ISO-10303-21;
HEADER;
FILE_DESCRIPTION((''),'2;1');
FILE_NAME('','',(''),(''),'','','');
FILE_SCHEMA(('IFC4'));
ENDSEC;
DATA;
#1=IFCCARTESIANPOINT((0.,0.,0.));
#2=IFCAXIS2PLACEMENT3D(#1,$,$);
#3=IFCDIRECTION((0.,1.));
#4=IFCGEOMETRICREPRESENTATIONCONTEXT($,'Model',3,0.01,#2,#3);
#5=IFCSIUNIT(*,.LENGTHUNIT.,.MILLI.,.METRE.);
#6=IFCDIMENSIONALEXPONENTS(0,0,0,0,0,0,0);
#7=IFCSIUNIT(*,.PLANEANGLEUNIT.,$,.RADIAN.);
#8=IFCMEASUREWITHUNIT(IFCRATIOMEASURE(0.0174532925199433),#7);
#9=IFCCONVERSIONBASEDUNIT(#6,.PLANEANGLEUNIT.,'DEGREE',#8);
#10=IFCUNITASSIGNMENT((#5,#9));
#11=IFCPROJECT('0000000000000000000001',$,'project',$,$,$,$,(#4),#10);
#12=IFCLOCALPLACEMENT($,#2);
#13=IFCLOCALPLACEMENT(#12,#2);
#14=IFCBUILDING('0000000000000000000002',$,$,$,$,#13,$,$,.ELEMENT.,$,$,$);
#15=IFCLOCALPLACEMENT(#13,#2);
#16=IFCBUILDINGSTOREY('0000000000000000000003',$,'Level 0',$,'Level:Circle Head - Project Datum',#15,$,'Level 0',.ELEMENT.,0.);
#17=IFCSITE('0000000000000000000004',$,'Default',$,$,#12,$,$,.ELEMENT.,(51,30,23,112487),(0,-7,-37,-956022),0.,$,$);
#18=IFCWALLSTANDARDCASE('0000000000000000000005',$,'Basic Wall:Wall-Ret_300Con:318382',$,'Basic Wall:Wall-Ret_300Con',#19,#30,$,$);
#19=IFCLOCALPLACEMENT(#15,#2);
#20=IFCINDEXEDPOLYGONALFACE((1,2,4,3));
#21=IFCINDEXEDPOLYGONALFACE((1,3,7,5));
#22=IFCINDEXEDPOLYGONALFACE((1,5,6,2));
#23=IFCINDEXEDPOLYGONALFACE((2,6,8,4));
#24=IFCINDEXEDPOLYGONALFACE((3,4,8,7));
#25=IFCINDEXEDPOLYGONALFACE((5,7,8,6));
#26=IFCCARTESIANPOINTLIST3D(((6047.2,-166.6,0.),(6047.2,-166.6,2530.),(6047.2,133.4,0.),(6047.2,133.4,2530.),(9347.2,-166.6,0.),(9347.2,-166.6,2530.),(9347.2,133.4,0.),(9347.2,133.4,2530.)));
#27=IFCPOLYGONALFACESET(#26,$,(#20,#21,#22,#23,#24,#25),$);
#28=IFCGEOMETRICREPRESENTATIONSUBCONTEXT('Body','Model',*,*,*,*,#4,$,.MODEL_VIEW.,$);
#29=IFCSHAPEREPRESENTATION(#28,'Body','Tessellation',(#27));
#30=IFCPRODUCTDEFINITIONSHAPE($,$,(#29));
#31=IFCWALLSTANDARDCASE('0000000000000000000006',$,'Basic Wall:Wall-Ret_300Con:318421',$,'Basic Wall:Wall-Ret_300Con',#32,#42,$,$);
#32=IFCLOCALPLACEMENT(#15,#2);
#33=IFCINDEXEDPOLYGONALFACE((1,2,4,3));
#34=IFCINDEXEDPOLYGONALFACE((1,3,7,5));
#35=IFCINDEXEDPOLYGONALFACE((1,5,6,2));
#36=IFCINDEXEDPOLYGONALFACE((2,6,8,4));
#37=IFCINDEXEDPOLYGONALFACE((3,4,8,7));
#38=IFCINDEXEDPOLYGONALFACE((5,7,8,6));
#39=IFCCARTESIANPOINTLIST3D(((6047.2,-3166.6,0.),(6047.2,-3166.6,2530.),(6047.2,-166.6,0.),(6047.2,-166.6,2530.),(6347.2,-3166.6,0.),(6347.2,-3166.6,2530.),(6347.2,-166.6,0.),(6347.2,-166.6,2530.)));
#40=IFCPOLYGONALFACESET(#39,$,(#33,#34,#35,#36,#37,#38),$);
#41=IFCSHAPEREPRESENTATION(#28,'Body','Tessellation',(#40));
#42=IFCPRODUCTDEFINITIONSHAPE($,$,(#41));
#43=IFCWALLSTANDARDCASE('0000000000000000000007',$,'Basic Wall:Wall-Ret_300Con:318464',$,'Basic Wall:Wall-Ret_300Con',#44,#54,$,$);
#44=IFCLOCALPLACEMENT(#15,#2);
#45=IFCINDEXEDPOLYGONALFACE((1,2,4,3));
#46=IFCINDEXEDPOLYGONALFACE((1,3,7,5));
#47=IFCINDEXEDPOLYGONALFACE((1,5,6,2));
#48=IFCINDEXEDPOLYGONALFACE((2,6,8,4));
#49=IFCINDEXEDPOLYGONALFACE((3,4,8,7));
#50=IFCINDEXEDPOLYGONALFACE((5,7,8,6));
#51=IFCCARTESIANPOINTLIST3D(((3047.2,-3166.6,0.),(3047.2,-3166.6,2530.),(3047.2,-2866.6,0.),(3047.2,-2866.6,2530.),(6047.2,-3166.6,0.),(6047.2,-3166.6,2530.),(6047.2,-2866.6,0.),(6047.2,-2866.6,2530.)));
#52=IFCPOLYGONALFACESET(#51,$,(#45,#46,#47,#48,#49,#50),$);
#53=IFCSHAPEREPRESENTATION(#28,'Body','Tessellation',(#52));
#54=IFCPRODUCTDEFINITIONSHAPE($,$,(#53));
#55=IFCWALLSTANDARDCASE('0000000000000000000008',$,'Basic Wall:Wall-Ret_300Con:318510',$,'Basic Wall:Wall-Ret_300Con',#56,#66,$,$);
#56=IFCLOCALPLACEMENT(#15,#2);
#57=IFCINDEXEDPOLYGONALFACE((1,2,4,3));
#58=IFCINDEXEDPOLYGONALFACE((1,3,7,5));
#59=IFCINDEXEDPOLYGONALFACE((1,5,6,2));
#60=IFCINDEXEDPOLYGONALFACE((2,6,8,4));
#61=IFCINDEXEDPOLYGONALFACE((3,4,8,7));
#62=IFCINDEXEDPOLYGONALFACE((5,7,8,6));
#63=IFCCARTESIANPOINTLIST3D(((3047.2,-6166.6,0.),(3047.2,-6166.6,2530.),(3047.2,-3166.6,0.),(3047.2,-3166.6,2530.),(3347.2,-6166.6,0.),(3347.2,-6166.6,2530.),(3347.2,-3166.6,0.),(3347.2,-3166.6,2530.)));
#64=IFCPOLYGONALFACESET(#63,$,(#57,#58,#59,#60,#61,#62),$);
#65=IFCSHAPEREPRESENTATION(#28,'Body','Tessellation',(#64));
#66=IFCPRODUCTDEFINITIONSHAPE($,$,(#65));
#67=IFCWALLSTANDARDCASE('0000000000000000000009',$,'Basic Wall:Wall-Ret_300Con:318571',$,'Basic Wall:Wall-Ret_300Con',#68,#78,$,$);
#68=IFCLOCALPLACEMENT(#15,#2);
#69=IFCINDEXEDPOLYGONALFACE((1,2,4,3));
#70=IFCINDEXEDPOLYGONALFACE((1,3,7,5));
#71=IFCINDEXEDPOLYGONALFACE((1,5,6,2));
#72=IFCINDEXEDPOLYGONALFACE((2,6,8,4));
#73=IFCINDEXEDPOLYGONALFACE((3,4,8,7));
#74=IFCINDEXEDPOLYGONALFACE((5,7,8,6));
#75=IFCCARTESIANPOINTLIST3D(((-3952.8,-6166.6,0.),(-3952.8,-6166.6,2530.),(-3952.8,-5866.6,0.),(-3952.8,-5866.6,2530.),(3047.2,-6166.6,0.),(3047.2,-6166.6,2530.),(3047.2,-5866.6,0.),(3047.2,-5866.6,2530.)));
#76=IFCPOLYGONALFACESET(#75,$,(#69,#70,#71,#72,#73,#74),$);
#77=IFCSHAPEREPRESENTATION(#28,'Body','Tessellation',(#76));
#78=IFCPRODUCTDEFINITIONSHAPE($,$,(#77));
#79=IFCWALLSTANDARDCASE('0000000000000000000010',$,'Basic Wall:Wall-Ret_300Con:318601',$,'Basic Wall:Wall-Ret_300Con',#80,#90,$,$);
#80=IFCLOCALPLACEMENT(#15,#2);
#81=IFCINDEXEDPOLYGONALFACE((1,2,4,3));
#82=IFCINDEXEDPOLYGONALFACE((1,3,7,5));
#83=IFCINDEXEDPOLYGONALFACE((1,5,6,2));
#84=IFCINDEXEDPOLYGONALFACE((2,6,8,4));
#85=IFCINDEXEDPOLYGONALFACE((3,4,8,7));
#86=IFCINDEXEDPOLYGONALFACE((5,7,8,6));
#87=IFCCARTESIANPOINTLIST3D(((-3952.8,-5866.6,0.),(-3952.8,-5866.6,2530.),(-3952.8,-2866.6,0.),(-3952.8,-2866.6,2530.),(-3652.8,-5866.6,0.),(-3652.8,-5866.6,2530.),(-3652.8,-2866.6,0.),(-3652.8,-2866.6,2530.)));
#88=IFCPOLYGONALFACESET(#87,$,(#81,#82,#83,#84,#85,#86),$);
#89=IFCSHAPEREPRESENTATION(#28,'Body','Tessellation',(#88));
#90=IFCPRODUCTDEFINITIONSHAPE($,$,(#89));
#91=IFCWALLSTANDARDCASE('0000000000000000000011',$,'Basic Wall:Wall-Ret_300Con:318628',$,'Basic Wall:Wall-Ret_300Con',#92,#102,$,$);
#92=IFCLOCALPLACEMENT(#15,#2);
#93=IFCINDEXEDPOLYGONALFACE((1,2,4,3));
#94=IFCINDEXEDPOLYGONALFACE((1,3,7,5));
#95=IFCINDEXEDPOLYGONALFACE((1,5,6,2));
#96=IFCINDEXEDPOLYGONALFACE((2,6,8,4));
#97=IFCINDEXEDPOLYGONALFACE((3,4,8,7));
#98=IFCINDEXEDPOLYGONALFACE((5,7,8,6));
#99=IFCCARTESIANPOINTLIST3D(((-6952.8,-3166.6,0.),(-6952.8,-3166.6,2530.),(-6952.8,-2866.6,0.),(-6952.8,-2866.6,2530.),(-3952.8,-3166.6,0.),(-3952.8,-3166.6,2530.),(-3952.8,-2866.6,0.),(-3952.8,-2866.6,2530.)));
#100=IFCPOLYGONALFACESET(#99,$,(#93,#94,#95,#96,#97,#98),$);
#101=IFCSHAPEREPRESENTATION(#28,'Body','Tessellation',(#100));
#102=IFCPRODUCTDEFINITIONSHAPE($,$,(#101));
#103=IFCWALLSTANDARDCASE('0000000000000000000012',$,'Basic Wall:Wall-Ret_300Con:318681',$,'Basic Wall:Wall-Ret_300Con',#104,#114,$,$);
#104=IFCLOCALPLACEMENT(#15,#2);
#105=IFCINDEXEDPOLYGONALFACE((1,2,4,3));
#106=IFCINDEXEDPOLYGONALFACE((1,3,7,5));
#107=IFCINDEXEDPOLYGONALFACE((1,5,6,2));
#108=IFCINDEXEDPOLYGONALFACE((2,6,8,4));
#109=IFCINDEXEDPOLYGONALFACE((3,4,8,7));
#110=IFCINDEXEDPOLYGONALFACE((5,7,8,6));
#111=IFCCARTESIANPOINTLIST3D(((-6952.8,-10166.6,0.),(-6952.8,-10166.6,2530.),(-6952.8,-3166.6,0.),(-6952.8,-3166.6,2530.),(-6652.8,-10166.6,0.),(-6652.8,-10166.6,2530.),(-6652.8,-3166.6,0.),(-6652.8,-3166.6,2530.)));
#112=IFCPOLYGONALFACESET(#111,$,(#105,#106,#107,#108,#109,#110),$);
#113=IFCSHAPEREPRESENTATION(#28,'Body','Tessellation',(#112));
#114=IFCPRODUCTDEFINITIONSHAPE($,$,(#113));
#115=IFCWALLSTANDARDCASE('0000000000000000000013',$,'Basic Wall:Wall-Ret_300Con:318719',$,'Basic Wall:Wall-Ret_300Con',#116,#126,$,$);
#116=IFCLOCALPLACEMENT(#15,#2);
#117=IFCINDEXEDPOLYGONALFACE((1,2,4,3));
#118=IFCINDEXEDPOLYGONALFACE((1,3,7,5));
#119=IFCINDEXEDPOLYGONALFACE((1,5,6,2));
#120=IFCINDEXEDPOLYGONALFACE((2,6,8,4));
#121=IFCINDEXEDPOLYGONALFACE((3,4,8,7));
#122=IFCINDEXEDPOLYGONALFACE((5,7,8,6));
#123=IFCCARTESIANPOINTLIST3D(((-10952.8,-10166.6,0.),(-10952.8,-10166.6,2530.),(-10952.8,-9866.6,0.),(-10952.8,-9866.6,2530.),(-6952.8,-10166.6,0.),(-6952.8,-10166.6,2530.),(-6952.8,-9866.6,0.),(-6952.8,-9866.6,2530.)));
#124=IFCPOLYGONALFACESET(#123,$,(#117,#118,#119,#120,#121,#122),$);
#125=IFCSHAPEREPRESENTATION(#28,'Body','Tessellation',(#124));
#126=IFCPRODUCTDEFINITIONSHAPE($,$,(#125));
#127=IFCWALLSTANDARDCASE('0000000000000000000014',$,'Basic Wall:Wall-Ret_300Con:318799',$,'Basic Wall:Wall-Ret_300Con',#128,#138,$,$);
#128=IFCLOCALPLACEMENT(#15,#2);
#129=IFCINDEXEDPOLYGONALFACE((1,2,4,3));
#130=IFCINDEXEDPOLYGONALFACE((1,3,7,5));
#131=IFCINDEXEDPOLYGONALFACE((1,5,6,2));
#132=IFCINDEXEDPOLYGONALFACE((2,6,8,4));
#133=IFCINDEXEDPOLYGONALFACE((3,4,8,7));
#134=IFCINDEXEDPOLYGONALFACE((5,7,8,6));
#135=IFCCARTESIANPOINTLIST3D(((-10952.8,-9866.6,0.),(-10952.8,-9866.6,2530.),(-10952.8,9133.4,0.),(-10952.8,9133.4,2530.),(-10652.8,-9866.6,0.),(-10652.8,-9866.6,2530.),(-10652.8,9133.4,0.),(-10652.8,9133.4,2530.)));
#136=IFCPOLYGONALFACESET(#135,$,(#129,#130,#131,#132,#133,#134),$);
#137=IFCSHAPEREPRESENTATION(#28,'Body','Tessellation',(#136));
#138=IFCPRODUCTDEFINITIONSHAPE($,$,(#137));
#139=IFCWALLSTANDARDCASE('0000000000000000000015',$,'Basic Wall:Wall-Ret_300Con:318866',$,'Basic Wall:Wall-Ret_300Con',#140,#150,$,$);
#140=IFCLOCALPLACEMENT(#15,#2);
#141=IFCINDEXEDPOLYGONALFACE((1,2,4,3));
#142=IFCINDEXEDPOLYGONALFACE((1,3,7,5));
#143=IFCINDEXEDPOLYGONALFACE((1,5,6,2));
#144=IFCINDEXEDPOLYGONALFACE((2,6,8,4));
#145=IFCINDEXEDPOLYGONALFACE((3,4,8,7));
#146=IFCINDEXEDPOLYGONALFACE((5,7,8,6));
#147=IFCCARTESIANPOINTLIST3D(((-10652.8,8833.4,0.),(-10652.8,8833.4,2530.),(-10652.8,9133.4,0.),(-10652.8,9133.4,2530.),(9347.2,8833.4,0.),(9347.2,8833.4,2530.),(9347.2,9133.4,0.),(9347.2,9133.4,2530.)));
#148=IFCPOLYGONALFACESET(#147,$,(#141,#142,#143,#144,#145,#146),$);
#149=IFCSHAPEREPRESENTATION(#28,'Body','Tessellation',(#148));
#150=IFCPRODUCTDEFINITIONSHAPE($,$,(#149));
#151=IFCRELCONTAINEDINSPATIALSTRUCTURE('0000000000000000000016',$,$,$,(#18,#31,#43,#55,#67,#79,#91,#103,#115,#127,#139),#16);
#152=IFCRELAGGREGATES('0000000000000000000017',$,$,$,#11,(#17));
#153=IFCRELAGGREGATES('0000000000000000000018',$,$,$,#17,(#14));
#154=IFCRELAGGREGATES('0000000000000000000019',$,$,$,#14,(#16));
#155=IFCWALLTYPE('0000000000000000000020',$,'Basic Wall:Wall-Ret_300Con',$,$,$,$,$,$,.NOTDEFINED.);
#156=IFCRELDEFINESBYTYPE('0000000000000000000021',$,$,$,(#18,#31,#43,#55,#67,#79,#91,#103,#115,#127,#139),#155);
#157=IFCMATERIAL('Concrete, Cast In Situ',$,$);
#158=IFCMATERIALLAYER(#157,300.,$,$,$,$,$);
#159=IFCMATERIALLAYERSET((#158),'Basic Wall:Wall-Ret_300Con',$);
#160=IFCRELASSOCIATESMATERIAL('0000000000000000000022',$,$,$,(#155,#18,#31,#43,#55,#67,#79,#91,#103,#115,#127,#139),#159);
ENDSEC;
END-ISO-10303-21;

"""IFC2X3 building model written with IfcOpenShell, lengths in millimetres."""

from ifc_helpers import new_model, entity, si_unit, converted_unit, direction, frame, frame_2d, origin, place, context, subcontext, project, spatial, polyline, rectangle, extrude, clip, bounded_halfspace, material, layer, layer_set, layer_usage, type_object, element, save


model = new_model("IFC2X3")

# Units and contexts
model_context = context("Model", 3, precision=0.01, world=origin(), true_north=direction((0.0, 1.0)))
body_context = subcontext(model_context, "Body", "Model", "MODEL_VIEW")
ifc_project = project(units=[si_unit("LENGTHUNIT", "METRE", prefix="MILLI"), converted_unit("PLANEANGLEUNIT", "DEGREE", entity("IfcRatioMeasure", 0.0174532925199433), si_unit("PLANEANGLEUNIT", "RADIAN"), dimensions=[0, 0, 0, 0, 0, 0, 0])], contexts=[model_context])

# Site, building, storey
site_placement = place(None, origin())
site = spatial("IfcSite", under=ifc_project, at=site_placement, Name="Default", CompositionType="ELEMENT", RefLatitude=(51, 30, 23, 112487), RefLongitude=(0, -7, -37, -956022), RefElevation=0.0)
building_placement = place(site_placement, origin())
building = spatial("IfcBuilding", under=site, at=building_placement, CompositionType="ELEMENT")
storey_placement = place(building_placement, origin())
storey = spatial("IfcBuildingStorey", under=building, at=storey_placement, Name="Level 0", ObjectType="Level:Circle Head - Project Datum", LongName="Level 0", CompositionType="ELEMENT", Elevation=0.0)

# Walls
ifc_material_1 = material(Name="Concrete, Cast In Situ")
ifc_layer_1 = layer(ifc_material_1, 300.0)
ifc_layer_set_1 = layer_set([ifc_layer_1], Name="Basic Wall:Wall-Ret_300Con")
ifc_layer_usage_1 = layer_usage(ifc_layer_set_1, "AXIS2", "NEGATIVE", 150.0)
wall_type = type_object("IfcWallType", Name="Basic Wall:Wall-Ret_300Con", PredefinedType="NOTDEFINED", material=ifc_layer_set_1)
wall_1_placement = place(storey_placement, frame((9347.2, -16.6, 0.0), z_axis=(0.0, 0.0, 1.0), x_axis=(-1.0, 0.0, 0.0)))
element("IfcWallStandardCase", 1, at=wall_1_placement, inside=storey, type_object=wall_type, material=ifc_layer_usage_1, Name="Basic Wall:Wall-Ret_300Con:318382", ObjectType="Basic Wall:Wall-Ret_300Con", context=body_context, shape_type="Clipping", body=[
    clip(extrude(rectangle(XDim=3300.0, YDim=300.0, at=frame_2d((1650.0, 0.0), x_axis=(-1.0, 0.0))), origin(), (0.0, 0.0, 1.0), 2530.0), bounded_halfspace(frame((0.0, -150.0, 2530.0), z_axis=(0.0, 0.0, -1.0), x_axis=(-1.0, 0.0, 0.0)), True, frame((0.0, -150.0, 2530.0)), polyline([(0.0, 0.0), (300.0, 0.0), (3300.0, 0.0), (3300.0, 300.0), (3000.0, 300.0), (0.0, 300.0), (0.0, 0.0)]))),
])
ifc_layer_usage_2 = layer_usage(ifc_layer_set_1, "AXIS2", "NEGATIVE", 150.0)
wall_2_placement = place(storey_placement, frame((6197.2, -166.6, 0.0), z_axis=(0.0, 0.0, 1.0), x_axis=(0.0, -1.0, 0.0)))
element("IfcWallStandardCase", 2, at=wall_2_placement, inside=storey, type_object=wall_type, material=ifc_layer_usage_2, Name="Basic Wall:Wall-Ret_300Con:318421", ObjectType="Basic Wall:Wall-Ret_300Con", context=body_context, shape_type="Clipping", body=[
    clip(extrude(rectangle(XDim=3000.0, YDim=300.0, at=frame_2d((1500.0, 0.0), x_axis=(-1.0, 0.0))), origin(), (0.0, 0.0, 1.0), 2530.0), bounded_halfspace(frame((0.0, -150.0, 2530.0), z_axis=(0.0, 0.0, -1.0), x_axis=(0.0, 1.0, 0.0)), True, frame((0.0, -150.0, 2530.0)), polyline([(0.0, 0.0), (2700.0, 0.0), (3000.0, 0.0), (3000.0, 300.0), (0.0, 300.0), (0.0, 0.0)]))),
])
ifc_layer_usage_3 = layer_usage(ifc_layer_set_1, "AXIS2", "NEGATIVE", 150.0)
wall_3_placement = place(storey_placement, frame((6047.2, -3016.6, 0.0), z_axis=(0.0, 0.0, 1.0), x_axis=(-1.0, 0.0, 0.0)))
element("IfcWallStandardCase", 3, at=wall_3_placement, inside=storey, type_object=wall_type, material=ifc_layer_usage_3, Name="Basic Wall:Wall-Ret_300Con:318464", ObjectType="Basic Wall:Wall-Ret_300Con", context=body_context, shape_type="Clipping", body=[
    clip(extrude(rectangle(XDim=3000.0, YDim=300.0, at=frame_2d((1500.0, 0.0), x_axis=(-1.0, 0.0))), origin(), (0.0, 0.0, 1.0), 2530.0), bounded_halfspace(frame((0.0, -150.0, 2530.0), z_axis=(0.0, 0.0, -1.0), x_axis=(-1.0, 0.0, 0.0)), True, frame((0.0, -150.0, 2530.0)), polyline([(0.0, 0.0), (3000.0, 0.0), (3000.0, 300.0), (2700.0, 300.0), (0.0, 300.0), (0.0, 0.0)]))),
])
ifc_layer_usage_4 = layer_usage(ifc_layer_set_1, "AXIS2", "NEGATIVE", 150.0)
wall_4_placement = place(storey_placement, frame((3197.2, -3166.6, 0.0), z_axis=(0.0, 0.0, 1.0), x_axis=(0.0, -1.0, 0.0)))
element("IfcWallStandardCase", 4, at=wall_4_placement, inside=storey, type_object=wall_type, material=ifc_layer_usage_4, Name="Basic Wall:Wall-Ret_300Con:318510", ObjectType="Basic Wall:Wall-Ret_300Con", context=body_context, shape_type="Clipping", body=[
    clip(extrude(rectangle(XDim=3000.0, YDim=300.0, at=frame_2d((1500.0, 0.0), x_axis=(-1.0, 0.0))), origin(), (0.0, 0.0, 1.0), 2530.0), bounded_halfspace(frame((0.0, -150.0, 2530.0), z_axis=(0.0, 0.0, -1.0), x_axis=(0.0, 1.0, 0.0)), True, frame((0.0, -150.0, 2530.0)), polyline([(0.0, 0.0), (2700.0, 0.0), (3000.0, 0.0), (3000.0, 300.0), (0.0, 300.0), (0.0, 0.0)]))),
])
ifc_layer_usage_5 = layer_usage(ifc_layer_set_1, "AXIS2", "NEGATIVE", 150.0)
wall_5_placement = place(storey_placement, frame((3047.2, -6016.6, 0.0), z_axis=(0.0, 0.0, 1.0), x_axis=(-1.0, 0.0, 0.0)))
element("IfcWallStandardCase", 5, at=wall_5_placement, inside=storey, type_object=wall_type, material=ifc_layer_usage_5, Name="Basic Wall:Wall-Ret_300Con:318571", ObjectType="Basic Wall:Wall-Ret_300Con", context=body_context, shape_type="Clipping", body=[
    clip(extrude(rectangle(XDim=7000.0, YDim=300.0, at=frame_2d((3500.0, 0.0), x_axis=(-1.0, 0.0))), origin(), (0.0, 0.0, 1.0), 2530.0), bounded_halfspace(frame((0.0, -150.0, 2530.0), z_axis=(0.0, 0.0, -1.0), x_axis=(-1.0, 0.0, 0.0)), True, frame((0.0, -150.0, 2530.0)), polyline([(0.0, 0.0), (6700.0, 0.0), (7000.0, 0.0), (7000.0, 300.0), (0.0, 300.0), (0.0, 0.0)]))),
])
ifc_layer_usage_6 = layer_usage(ifc_layer_set_1, "AXIS2", "NEGATIVE", 150.0)
wall_6_placement = place(storey_placement, frame((-3802.8, -5866.6, 0.0), z_axis=(0.0, 0.0, 1.0), x_axis=(0.0, 1.0, 0.0)))
element("IfcWallStandardCase", 6, at=wall_6_placement, inside=storey, type_object=wall_type, material=ifc_layer_usage_6, Name="Basic Wall:Wall-Ret_300Con:318601", ObjectType="Basic Wall:Wall-Ret_300Con", context=body_context, shape_type="Clipping", body=[
    clip(extrude(rectangle(XDim=3000.0, YDim=300.0, at=frame_2d((1500.0, 0.0), x_axis=(-1.0, 0.0))), origin(), (0.0, 0.0, 1.0), 2530.0), bounded_halfspace(frame((0.0, -150.0, 2530.0), z_axis=(0.0, 0.0, -1.0), x_axis=(0.0, -1.0, 0.0)), True, frame((0.0, -150.0, 2530.0)), polyline([(0.0, 0.0), (3000.0, 0.0), (3000.0, 300.0), (2700.0, 300.0), (0.0, 300.0), (0.0, 0.0)]))),
])
ifc_layer_usage_7 = layer_usage(ifc_layer_set_1, "AXIS2", "NEGATIVE", 150.0)
wall_7_placement = place(storey_placement, frame((-3952.8, -3016.6, 0.0), z_axis=(0.0, 0.0, 1.0), x_axis=(-1.0, 0.0, 0.0)))
element("IfcWallStandardCase", 7, at=wall_7_placement, inside=storey, type_object=wall_type, material=ifc_layer_usage_7, Name="Basic Wall:Wall-Ret_300Con:318628", ObjectType="Basic Wall:Wall-Ret_300Con", context=body_context, shape_type="Clipping", body=[
    clip(extrude(rectangle(XDim=3000.0, YDim=300.0, at=frame_2d((1500.0, 0.0), x_axis=(-1.0, 0.0))), origin(), (0.0, 0.0, 1.0), 2530.0), bounded_halfspace(frame((0.0, -150.0, 2530.0), z_axis=(0.0, 0.0, -1.0), x_axis=(-1.0, 0.0, 0.0)), True, frame((0.0, -150.0, 2530.0)), polyline([(0.0, 0.0), (3000.0, 0.0), (3000.0, 300.0), (2700.0, 300.0), (0.0, 300.0), (0.0, 0.0)]))),
])
ifc_layer_usage_8 = layer_usage(ifc_layer_set_1, "AXIS2", "NEGATIVE", 150.0)
wall_8_placement = place(storey_placement, frame((-6802.8, -3166.6, 0.0), z_axis=(0.0, 0.0, 1.0), x_axis=(0.0, -1.0, 0.0)))
element("IfcWallStandardCase", 8, at=wall_8_placement, inside=storey, type_object=wall_type, material=ifc_layer_usage_8, Name="Basic Wall:Wall-Ret_300Con:318681", ObjectType="Basic Wall:Wall-Ret_300Con", context=body_context, shape_type="Clipping", body=[
    clip(extrude(rectangle(XDim=7000.0, YDim=300.0, at=frame_2d((3500.0, 0.0), x_axis=(-1.0, 0.0))), origin(), (0.0, 0.0, 1.0), 2530.0), bounded_halfspace(frame((0.0, -150.0, 2530.0), z_axis=(0.0, 0.0, -1.0), x_axis=(0.0, 1.0, 0.0)), True, frame((0.0, -150.0, 2530.0)), polyline([(0.0, 0.0), (6700.0, 0.0), (7000.0, 0.0), (7000.0, 300.0), (0.0, 300.0), (0.0, 0.0)]))),
])
ifc_layer_usage_9 = layer_usage(ifc_layer_set_1, "AXIS2", "NEGATIVE", 150.0)
wall_9_placement = place(storey_placement, frame((-6952.8, -10016.6, 0.0), z_axis=(0.0, 0.0, 1.0), x_axis=(-1.0, 0.0, 0.0)))
element("IfcWallStandardCase", 9, at=wall_9_placement, inside=storey, type_object=wall_type, material=ifc_layer_usage_9, Name="Basic Wall:Wall-Ret_300Con:318719", ObjectType="Basic Wall:Wall-Ret_300Con", context=body_context, shape_type="Clipping", body=[
    clip(extrude(rectangle(XDim=4000.0, YDim=300.0, at=frame_2d((2000.0, 0.0), x_axis=(-1.0, 0.0))), origin(), (0.0, 0.0, 1.0), 2530.0), bounded_halfspace(frame((0.0, -150.0, 2530.0), z_axis=(0.0, 0.0, -1.0), x_axis=(-1.0, 0.0, 0.0)), True, frame((0.0, -150.0, 2530.0)), polyline([(0.0, 0.0), (3700.0, 0.0), (4000.0, 0.0), (4000.0, 300.0), (0.0, 300.0), (0.0, 0.0)]))),
])
ifc_layer_usage_10 = layer_usage(ifc_layer_set_1, "AXIS2", "NEGATIVE", 150.0)
wall_10_placement = place(storey_placement, frame((-10802.8, -9866.6, 0.0), z_axis=(0.0, 0.0, 1.0), x_axis=(0.0, 1.0, 0.0)))
element("IfcWallStandardCase", 10, at=wall_10_placement, inside=storey, type_object=wall_type, material=ifc_layer_usage_10, Name="Basic Wall:Wall-Ret_300Con:318799", ObjectType="Basic Wall:Wall-Ret_300Con", context=body_context, shape_type="Clipping", body=[
    clip(extrude(rectangle(XDim=19000.0, YDim=300.0, at=frame_2d((9500.0, 0.0), x_axis=(-1.0, 0.0))), origin(), (0.0, 0.0, 1.0), 2530.0), bounded_halfspace(frame((0.0, -150.0, 2530.0), z_axis=(0.0, 0.0, -1.0), x_axis=(0.0, -1.0, 0.0)), True, frame((0.0, -150.0, 2530.0)), polyline([(0.0, 0.0), (18700.0, 0.0), (19000.0, 0.0), (19000.0, 300.0), (0.0, 300.0), (0.0, 0.0)]))),
])
ifc_layer_usage_11 = layer_usage(ifc_layer_set_1, "AXIS2", "NEGATIVE", 150.0)
wall_11_placement = place(storey_placement, frame((-10652.8, 8983.4, 0.0)))
element("IfcWallStandardCase", 11, at=wall_11_placement, inside=storey, type_object=wall_type, material=ifc_layer_usage_11, Name="Basic Wall:Wall-Ret_300Con:318866", ObjectType="Basic Wall:Wall-Ret_300Con", context=body_context, shape_type="Clipping", body=[
    clip(extrude(rectangle(XDim=20000.0, YDim=300.0, at=frame_2d((10000.0, 0.0), x_axis=(-1.0, 0.0))), origin(), (0.0, 0.0, 1.0), 2530.0), bounded_halfspace(frame((0.0, -150.0, 2530.0), z_axis=(0.0, 0.0, -1.0), x_axis=(1.0, 0.0, 0.0)), True, frame((0.0, -150.0, 2530.0)), polyline([(0.0, 0.0), (19700.0, 0.0), (20000.0, 0.0), (20000.0, 300.0), (0.0, 300.0), (0.0, 0.0)]))),
])

save(model, "model.ifc")
